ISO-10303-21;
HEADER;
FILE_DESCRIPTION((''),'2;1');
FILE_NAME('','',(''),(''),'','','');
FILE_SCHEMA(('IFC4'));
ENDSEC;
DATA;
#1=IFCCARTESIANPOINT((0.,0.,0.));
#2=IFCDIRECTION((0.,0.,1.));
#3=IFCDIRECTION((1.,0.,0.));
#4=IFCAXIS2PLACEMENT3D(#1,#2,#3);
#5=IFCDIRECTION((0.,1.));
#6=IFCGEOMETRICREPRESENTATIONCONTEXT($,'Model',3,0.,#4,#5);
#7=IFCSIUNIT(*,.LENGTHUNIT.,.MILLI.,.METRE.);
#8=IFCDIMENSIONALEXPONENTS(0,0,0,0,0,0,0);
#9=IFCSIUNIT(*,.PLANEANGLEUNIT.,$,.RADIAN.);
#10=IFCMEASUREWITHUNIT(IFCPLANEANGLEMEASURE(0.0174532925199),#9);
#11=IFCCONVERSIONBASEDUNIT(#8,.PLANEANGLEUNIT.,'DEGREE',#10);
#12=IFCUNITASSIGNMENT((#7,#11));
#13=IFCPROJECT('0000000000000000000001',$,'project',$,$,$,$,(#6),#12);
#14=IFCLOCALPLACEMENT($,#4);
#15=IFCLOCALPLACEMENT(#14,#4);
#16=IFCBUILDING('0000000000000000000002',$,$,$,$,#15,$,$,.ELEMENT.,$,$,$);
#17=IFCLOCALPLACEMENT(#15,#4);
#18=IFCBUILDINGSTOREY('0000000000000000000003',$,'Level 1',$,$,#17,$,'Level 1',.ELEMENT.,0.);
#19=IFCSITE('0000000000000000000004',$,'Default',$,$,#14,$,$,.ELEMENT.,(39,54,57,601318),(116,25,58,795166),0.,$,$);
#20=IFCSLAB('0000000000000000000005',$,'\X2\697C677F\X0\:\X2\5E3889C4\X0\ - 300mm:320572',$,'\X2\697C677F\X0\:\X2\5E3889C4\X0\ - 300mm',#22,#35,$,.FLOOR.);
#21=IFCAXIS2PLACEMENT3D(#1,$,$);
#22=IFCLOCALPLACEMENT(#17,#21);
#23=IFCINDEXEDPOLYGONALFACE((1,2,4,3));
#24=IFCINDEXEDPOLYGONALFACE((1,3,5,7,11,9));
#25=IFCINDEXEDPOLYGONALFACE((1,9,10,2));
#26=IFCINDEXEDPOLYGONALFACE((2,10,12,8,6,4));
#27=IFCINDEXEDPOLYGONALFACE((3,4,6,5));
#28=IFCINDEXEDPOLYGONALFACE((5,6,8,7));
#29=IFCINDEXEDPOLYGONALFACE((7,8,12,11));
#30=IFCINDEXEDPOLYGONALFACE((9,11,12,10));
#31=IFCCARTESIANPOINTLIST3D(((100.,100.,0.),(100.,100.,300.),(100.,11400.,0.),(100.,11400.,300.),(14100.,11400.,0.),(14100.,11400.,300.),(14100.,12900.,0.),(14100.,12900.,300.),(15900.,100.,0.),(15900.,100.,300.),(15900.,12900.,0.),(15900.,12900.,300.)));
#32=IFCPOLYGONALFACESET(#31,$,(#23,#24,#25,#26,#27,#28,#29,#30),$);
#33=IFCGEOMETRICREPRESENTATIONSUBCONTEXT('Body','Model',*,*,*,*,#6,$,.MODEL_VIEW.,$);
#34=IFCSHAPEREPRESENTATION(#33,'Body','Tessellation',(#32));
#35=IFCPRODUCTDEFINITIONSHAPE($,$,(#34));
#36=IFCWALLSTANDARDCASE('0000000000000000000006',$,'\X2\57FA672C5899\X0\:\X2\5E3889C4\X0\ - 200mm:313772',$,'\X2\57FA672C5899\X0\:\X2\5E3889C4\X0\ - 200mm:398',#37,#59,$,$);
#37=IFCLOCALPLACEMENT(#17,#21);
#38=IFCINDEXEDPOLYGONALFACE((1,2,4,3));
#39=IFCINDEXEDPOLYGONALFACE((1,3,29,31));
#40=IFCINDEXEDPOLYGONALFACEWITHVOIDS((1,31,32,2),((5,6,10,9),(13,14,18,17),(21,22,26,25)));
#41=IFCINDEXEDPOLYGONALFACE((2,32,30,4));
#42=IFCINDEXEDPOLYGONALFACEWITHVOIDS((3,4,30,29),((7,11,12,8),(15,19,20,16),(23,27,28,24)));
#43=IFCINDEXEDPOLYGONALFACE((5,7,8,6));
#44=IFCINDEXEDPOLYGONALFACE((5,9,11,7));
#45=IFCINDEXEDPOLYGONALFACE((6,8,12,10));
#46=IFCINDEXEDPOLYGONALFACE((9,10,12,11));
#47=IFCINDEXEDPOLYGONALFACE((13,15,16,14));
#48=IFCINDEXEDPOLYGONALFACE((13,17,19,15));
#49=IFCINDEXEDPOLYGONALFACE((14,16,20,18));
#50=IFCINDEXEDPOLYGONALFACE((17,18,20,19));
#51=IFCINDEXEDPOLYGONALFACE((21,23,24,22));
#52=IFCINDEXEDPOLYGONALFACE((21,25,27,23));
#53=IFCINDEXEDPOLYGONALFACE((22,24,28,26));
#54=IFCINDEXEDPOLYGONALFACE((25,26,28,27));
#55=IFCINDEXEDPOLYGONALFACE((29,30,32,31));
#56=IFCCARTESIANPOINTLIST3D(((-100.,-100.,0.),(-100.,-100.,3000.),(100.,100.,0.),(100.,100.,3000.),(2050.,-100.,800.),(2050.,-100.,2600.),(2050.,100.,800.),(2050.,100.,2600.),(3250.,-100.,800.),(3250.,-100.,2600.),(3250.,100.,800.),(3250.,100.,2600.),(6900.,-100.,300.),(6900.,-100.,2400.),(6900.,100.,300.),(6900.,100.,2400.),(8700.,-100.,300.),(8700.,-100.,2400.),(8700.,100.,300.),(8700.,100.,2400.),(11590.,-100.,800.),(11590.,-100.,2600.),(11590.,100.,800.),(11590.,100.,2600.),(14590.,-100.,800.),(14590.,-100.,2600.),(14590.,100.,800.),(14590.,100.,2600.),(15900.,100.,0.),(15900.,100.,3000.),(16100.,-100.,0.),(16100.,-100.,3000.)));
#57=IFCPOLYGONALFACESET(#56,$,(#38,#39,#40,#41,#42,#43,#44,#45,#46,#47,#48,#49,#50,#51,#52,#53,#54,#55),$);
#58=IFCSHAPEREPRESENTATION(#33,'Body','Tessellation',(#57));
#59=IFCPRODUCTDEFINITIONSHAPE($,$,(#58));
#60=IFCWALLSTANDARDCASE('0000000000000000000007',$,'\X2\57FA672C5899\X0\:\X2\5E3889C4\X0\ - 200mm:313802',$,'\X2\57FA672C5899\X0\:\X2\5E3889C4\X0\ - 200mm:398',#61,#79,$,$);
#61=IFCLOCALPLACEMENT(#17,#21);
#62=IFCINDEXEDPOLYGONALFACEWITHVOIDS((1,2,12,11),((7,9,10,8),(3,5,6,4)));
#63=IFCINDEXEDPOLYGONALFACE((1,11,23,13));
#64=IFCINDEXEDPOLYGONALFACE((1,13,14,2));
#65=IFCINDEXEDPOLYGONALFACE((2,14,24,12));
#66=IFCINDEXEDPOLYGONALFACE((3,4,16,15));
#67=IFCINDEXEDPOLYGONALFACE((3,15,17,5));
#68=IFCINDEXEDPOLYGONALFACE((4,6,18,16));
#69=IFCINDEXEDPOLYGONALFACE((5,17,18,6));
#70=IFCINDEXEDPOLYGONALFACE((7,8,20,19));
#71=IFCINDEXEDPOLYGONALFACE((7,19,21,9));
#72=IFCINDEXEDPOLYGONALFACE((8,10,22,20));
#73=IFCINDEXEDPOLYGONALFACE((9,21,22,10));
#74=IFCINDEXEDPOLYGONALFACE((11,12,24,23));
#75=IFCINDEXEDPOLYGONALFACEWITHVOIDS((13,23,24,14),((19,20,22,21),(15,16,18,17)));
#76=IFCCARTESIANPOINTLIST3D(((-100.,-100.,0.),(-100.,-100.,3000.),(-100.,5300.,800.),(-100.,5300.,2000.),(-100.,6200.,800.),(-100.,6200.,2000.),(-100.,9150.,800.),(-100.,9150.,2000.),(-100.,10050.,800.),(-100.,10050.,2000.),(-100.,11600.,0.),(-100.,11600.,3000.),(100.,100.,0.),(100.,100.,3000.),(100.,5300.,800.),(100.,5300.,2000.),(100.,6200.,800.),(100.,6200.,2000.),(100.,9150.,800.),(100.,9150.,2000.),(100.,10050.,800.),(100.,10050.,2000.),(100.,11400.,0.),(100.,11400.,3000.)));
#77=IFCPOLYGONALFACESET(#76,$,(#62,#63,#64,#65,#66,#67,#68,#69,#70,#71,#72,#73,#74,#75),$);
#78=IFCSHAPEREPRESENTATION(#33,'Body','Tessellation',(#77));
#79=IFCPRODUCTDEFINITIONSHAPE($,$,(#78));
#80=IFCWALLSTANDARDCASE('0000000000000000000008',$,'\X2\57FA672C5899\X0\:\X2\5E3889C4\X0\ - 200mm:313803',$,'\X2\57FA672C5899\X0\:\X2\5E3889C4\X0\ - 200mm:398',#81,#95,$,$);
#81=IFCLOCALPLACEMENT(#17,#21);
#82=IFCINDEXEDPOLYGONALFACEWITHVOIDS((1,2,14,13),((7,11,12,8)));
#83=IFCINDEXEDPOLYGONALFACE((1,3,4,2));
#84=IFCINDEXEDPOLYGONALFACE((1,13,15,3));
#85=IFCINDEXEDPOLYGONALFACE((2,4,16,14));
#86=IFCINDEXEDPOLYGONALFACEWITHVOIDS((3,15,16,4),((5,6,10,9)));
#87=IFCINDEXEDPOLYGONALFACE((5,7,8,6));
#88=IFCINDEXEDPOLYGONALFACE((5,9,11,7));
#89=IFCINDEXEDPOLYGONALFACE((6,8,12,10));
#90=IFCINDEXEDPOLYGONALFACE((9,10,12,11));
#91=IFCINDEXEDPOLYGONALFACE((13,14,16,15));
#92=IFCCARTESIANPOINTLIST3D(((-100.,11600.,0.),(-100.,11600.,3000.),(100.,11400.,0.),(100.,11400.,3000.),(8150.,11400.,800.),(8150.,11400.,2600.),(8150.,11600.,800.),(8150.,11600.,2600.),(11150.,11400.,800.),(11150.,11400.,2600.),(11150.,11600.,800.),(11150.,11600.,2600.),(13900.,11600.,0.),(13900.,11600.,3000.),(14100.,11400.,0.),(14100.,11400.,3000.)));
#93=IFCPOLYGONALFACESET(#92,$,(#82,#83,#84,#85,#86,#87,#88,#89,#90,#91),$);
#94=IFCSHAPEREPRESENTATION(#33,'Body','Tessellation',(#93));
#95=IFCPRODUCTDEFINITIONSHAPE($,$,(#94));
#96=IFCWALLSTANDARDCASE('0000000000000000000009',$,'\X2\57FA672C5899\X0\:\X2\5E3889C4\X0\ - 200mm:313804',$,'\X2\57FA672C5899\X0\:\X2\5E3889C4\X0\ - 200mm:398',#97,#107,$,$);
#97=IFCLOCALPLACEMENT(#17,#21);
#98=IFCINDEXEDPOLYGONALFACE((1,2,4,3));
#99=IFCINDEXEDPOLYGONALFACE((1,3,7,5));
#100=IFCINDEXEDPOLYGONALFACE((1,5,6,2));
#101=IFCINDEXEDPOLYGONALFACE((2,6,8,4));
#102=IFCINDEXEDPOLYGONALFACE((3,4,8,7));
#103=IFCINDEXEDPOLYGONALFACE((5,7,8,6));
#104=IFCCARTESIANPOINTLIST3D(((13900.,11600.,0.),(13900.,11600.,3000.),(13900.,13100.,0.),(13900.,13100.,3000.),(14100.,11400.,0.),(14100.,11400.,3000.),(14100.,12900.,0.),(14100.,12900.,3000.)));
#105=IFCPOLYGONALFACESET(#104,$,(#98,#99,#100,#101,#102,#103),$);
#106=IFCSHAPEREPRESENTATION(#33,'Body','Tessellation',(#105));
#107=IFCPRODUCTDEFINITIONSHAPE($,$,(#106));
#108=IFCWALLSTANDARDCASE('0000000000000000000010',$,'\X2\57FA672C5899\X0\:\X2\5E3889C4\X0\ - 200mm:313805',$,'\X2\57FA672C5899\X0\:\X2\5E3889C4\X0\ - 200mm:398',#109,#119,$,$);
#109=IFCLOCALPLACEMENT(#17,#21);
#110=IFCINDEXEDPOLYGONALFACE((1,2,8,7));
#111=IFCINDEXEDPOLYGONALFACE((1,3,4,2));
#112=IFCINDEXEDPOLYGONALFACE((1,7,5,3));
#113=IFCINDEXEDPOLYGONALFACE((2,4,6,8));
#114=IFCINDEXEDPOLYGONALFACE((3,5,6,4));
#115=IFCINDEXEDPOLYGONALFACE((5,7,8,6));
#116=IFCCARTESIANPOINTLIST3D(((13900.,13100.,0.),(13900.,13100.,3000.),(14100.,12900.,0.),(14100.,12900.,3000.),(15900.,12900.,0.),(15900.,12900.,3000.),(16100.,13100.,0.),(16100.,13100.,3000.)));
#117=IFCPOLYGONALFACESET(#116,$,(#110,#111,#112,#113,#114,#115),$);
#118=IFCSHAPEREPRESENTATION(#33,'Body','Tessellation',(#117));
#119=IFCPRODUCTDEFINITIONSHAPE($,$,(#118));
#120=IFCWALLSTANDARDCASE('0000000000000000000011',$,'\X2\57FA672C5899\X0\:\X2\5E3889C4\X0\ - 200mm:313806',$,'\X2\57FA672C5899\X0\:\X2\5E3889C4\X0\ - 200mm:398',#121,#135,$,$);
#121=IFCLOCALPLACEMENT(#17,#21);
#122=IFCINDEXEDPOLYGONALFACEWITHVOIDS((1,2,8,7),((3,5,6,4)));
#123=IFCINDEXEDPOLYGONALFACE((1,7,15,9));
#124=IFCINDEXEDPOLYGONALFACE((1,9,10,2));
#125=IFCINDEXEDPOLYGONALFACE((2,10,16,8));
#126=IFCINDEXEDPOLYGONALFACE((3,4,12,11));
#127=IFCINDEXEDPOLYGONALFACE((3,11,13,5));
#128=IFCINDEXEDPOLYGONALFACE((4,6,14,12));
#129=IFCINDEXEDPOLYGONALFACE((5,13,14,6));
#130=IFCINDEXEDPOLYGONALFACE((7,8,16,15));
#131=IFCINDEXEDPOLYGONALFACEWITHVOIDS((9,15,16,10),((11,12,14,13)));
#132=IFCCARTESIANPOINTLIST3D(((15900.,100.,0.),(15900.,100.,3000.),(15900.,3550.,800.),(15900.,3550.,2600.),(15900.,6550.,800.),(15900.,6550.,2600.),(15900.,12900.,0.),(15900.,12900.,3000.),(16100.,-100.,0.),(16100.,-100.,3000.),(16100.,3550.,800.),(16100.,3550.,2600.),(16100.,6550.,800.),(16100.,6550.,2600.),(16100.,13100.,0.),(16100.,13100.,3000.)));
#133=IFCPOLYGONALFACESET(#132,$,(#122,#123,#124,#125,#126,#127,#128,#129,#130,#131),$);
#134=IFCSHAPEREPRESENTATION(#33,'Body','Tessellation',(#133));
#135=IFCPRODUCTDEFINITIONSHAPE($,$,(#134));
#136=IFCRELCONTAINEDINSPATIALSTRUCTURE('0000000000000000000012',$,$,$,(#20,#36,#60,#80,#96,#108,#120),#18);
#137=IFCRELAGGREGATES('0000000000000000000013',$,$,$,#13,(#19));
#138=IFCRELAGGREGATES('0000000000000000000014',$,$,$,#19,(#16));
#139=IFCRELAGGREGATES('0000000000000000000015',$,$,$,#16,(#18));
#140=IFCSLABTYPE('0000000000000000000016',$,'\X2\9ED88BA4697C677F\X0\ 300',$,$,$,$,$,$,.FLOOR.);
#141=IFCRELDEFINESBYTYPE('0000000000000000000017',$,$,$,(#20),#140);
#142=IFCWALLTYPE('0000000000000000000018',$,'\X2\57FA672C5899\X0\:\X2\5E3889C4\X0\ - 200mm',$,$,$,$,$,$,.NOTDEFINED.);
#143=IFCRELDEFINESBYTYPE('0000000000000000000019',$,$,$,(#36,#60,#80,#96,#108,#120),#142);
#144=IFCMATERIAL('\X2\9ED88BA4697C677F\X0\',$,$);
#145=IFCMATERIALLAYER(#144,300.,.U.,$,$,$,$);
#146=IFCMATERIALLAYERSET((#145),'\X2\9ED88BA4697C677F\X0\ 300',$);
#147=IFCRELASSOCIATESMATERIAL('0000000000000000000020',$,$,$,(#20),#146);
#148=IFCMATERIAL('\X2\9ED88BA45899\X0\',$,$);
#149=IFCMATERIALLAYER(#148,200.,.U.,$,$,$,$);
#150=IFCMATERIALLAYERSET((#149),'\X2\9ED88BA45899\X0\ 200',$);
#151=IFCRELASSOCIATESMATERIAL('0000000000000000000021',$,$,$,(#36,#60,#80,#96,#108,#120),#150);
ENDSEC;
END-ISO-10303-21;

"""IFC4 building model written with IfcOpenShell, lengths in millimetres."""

from ifc_helpers import new_model, entity, si_unit, converted_unit, direction, frame, origin_with_axes, place, context, subcontext, project, spatial, polyline, outline, extrude, material, layer, layer_set, layer_usage, type_object, element, save


model = new_model("IFC4")

# Units and contexts
model_context_1 = context("Model", 3, precision=0.0, world=origin_with_axes(), true_north=direction((0.0, 1.0)))
model_context_2 = context("Model", 3, precision=0.0, world=origin_with_axes(), true_north=direction((0.0, 1.0)))
body_context_1 = subcontext(model_context_1, "Body", "Model", "MODEL_VIEW")
body_context_2 = subcontext(model_context_2, "Body", "Model", "MODEL_VIEW")
ifc_project = project(units=[si_unit("LENGTHUNIT", "METRE", prefix="MILLI"), converted_unit("PLANEANGLEUNIT", "DEGREE", entity("IfcPlaneAngleMeasure", 0.0174532925199), si_unit("PLANEANGLEUNIT", "RADIAN"), dimensions=[0, 0, 0, 0, 0, 0, 0])], contexts=[model_context_1])

# Site, building, storey
site_placement = place(None, origin_with_axes())
site = spatial("IfcSite", under=ifc_project, at=site_placement, Name="Default", CompositionType="ELEMENT", RefLatitude=(39, 54, 57, 601318), RefLongitude=(116, 25, 58, 795166), RefElevation=0.0)
building_placement = place(site_placement, origin_with_axes())
building = spatial("IfcBuilding", under=site, at=building_placement, CompositionType="ELEMENT")
storey_placement = place(building_placement, origin_with_axes())
storey = spatial("IfcBuildingStorey", under=building, at=storey_placement, Name="Level 1", LongName="Level 1", CompositionType="ELEMENT", Elevation=0.0)

# Slab
ifc_material_1 = material(Name="默认楼板")
ifc_layer_1 = layer(ifc_material_1, 300.0, ventilated="UNKNOWN")
ifc_layer_set_1 = layer_set([ifc_layer_1], Name="默认楼板 300")
ifc_layer_usage_1 = layer_usage(ifc_layer_set_1, "AXIS3", "NEGATIVE", 300.0)
slab_type = type_object("IfcSlabType", Name="默认楼板 300", PredefinedType="FLOOR")
slab_placement = place(storey_placement, frame((100.0, 100.0, 0.0), z_axis=(0.0, 0.0, 1.0), x_axis=(1.0, 0.0, 0.0)))
element("IfcSlab", 1, at=slab_placement, inside=storey, type_object=slab_type, material=ifc_layer_usage_1, Name="楼板:常规 - 300mm:320572", ObjectType="楼板:常规 - 300mm", PredefinedType="FLOOR", context=body_context_1, shape_type="SweptSolid", body=[
    extrude(outline(polyline([(0.0, 0.0), (15800.0, 0.0), (15800.0, 12800.0), (14000.0, 12800.0), (14000.0, 11300.0), (0.0, 11300.0), (0.0, 0.0)])), origin_with_axes(), (0.0, 0.0, 1.0), 300.0),
])

# Walls, openings
ifc_material_2 = material(Name="默认墙")
ifc_layer_2 = layer(ifc_material_2, 200.0, ventilated="UNKNOWN")
ifc_layer_set_2 = layer_set([ifc_layer_2], Name="默认墙 200")
ifc_layer_usage_2 = layer_usage(ifc_layer_set_2, "AXIS2", "POSITIVE", -100.0)
wall_type_1 = type_object("IfcWallType", Name="基本墙:常规 - 200mm", PredefinedType="NOTDEFINED")
wall_1_placement = place(storey_placement, frame((16000.0, 0.0, 0.0), z_axis=(0.0, 0.0, 1.0), x_axis=(-1.0, 0.0, 0.0)))
wall_1 = element("IfcWallStandardCase", 2, at=wall_1_placement, inside=storey, type_object=wall_type_1, material=ifc_layer_usage_2, Name="基本墙:常规 - 200mm:313772", ObjectType="基本墙:常规 - 200mm:398", context=body_context_1, shape_type="SweptSolid", body=[
    extrude(outline(polyline([(100.0, -100.0), (15900.0, -100.0), (16100.0, 100.0), (-100.0, 100.0), (100.0, -100.0)])), origin_with_axes(), (0.0, 0.0, 1.0), 3000.0),
])
placement_1 = place(None, origin_with_axes())
placement_2 = place(placement_1, origin_with_axes())
placement_3 = place(placement_2, origin_with_axes())
placement_4 = place(placement_3, frame((16000.0, 0.0, 0.0), z_axis=(0.0, 0.0, 1.0), x_axis=(-1.0, 0.0, 0.0)))
opening_1_placement = place(placement_4, frame((13350.0, 0.0, 800.0), z_axis=(0.0, 0.0, 1.0), x_axis=(1.0, 0.0, 0.0)))
element("IfcOpeningElement", 3, at=opening_1_placement, cuts=wall_1, context=body_context_2, shape_type="SweptSolid", body=[
    extrude(outline(polyline([(-600.0, 0.0), (-600.0, -1800.0), (600.0, -1800.0), (600.0, 0.0), (-600.0, 0.0)])), frame((0.0, -100.0, 0.0), z_axis=(0.0, 1.0, 0.0), x_axis=(1.0, 0.0, 0.0)), (0.0, 0.0, 1.0), 200.0),
])
opening_2_placement = place(placement_4, frame((2910.0, 0.0, 800.0), z_axis=(0.0, 0.0, 1.0), x_axis=(1.0, 0.0, 0.0)))
element("IfcOpeningElement", 4, at=opening_2_placement, cuts=wall_1, context=body_context_2, shape_type="SweptSolid", body=[
    extrude(outline(polyline([(-1500.0, 0.0), (-1500.0, -1800.0), (1500.0, -1800.0), (1500.0, 0.0), (-1500.0, 0.0)])), frame((0.0, -100.0, 0.0), z_axis=(0.0, 1.0, 0.0), x_axis=(1.0, 0.0, 0.0)), (0.0, 0.0, 1.0), 200.0),
])
opening_3_placement = place(placement_4, frame((8200.0, 0.0, 300.0), z_axis=(0.0, 0.0, 1.0), x_axis=(1.0, 0.0, 0.0)))
element("IfcOpeningElement", 5, at=opening_3_placement, cuts=wall_1, context=body_context_2, shape_type="SweptSolid", body=[
    extrude(outline(polyline([(-900.0, 0.0), (-900.0, -2100.0), (900.0, -2100.0), (900.0, 0.0), (-900.0, 0.0)])), frame((0.0, -100.0, 0.0), z_axis=(0.0, 1.0, 0.0), x_axis=(1.0, 0.0, 0.0)), (0.0, 0.0, 1.0), 200.0),
])
ifc_layer_usage_3 = layer_usage(ifc_layer_set_2, "AXIS2", "POSITIVE", -100.0)
wall_2_placement = place(storey_placement, frame((0.0, 0.0, 0.0), z_axis=(0.0, 0.0, 1.0), x_axis=(0.0, 1.0, 0.0)))
wall_2 = element("IfcWallStandardCase", 6, at=wall_2_placement, inside=storey, type_object=wall_type_1, material=ifc_layer_usage_3, Name="基本墙:常规 - 200mm:313802", ObjectType="基本墙:常规 - 200mm:398", context=body_context_1, shape_type="SweptSolid", body=[
    extrude(outline(polyline([(100.0, -100.0), (11400.0, -100.0), (11600.0, 100.0), (-100.0, 100.0), (100.0, -100.0)])), origin_with_axes(), (0.0, 0.0, 1.0), 3000.0),
])
placement_5 = place(placement_3, frame((0.0, 0.0, 0.0), z_axis=(0.0, 0.0, 1.0), x_axis=(0.0, 1.0, 0.0)))
opening_4_placement = place(placement_5, frame((5750.0, 0.0, 800.0), z_axis=(0.0, 0.0, 1.0), x_axis=(1.0, 0.0, 0.0)))
element("IfcOpeningElement", 7, at=opening_4_placement, cuts=wall_2, context=body_context_2, shape_type="SweptSolid", body=[
    extrude(outline(polyline([(450.0, -1200.0), (450.0, 0.0), (-450.0, 0.0), (-450.0, -1200.0), (450.0, -1200.0)])), frame((0.0, 100.0, 0.0), z_axis=(0.0, -1.0, 0.0), x_axis=(-1.0, 0.0, 0.0)), (0.0, 0.0, 1.0), 200.0),
])
opening_5_placement = place(placement_5, frame((9600.0, 0.0, 800.0), z_axis=(0.0, 0.0, 1.0), x_axis=(1.0, 0.0, 0.0)))
element("IfcOpeningElement", 8, at=opening_5_placement, cuts=wall_2, context=body_context_2, shape_type="SweptSolid", body=[
    extrude(outline(polyline([(450.0, -1200.0), (450.0, 0.0), (-450.0, 0.0), (-450.0, -1200.0), (450.0, -1200.0)])), frame((0.0, 100.0, 0.0), z_axis=(0.0, -1.0, 0.0), x_axis=(-1.0, 0.0, 0.0)), (0.0, 0.0, 1.0), 200.0),
])

# Wall, opening
ifc_layer_usage_4 = layer_usage(ifc_layer_set_2, "AXIS2", "POSITIVE", -100.0)
wall_3_placement = place(storey_placement, frame((0.0, 11500.0, 0.0), z_axis=(0.0, 0.0, 1.0), x_axis=(1.0, 0.0, 0.0)))
wall_3 = element("IfcWallStandardCase", 9, at=wall_3_placement, inside=storey, type_object=wall_type_1, material=ifc_layer_usage_4, Name="基本墙:常规 - 200mm:313803", ObjectType="基本墙:常规 - 200mm:398", context=body_context_1, shape_type="SweptSolid", body=[
    extrude(outline(polyline([(100.0, -100.0), (14100.0, -100.0), (13900.0, 100.0), (-100.0, 100.0), (100.0, -100.0)])), origin_with_axes(), (0.0, 0.0, 1.0), 3000.0),
])
placement_6 = place(placement_3, frame((0.0, 11500.0, 0.0), z_axis=(0.0, 0.0, 1.0), x_axis=(1.0, 0.0, 0.0)))
opening_6_placement = place(placement_6, frame((9650.0, 0.0, 800.0), z_axis=(0.0, 0.0, 1.0), x_axis=(1.0, 0.0, 0.0)))
element("IfcOpeningElement", 10, at=opening_6_placement, cuts=wall_3, context=body_context_2, shape_type="SweptSolid", body=[
    extrude(outline(polyline([(-1500.0, 0.0), (-1500.0, -1800.0), (1500.0, -1800.0), (1500.0, 0.0), (-1500.0, 0.0)])), frame((0.0, -100.0, 0.0), z_axis=(0.0, 1.0, 0.0), x_axis=(1.0, 0.0, 0.0)), (0.0, 0.0, 1.0), 200.0),
])

# Walls
ifc_layer_usage_5 = layer_usage(ifc_layer_set_2, "AXIS2", "POSITIVE", -100.0)
wall_4_placement = place(storey_placement, frame((14000.0, 11500.0, 0.0), z_axis=(0.0, 0.0, 1.0), x_axis=(0.0, 1.0, 0.0)))
element("IfcWallStandardCase", 11, at=wall_4_placement, inside=storey, type_object=wall_type_1, material=ifc_layer_usage_5, Name="基本墙:常规 - 200mm:313804", ObjectType="基本墙:常规 - 200mm:398", context=body_context_1, shape_type="SweptSolid", body=[
    extrude(outline(polyline([(-100.0, -100.0), (1400.0, -100.0), (1600.0, 100.0), (100.0, 100.0), (-100.0, -100.0)])), origin_with_axes(), (0.0, 0.0, 1.0), 3000.0),
])
ifc_layer_usage_6 = layer_usage(ifc_layer_set_2, "AXIS2", "POSITIVE", -100.0)
wall_5_placement = place(storey_placement, frame((14000.0, 13000.0, 0.0), z_axis=(0.0, 0.0, 1.0), x_axis=(1.0, 0.0, 0.0)))
element("IfcWallStandardCase", 12, at=wall_5_placement, inside=storey, type_object=wall_type_1, material=ifc_layer_usage_6, Name="基本墙:常规 - 200mm:313805", ObjectType="基本墙:常规 - 200mm:398", context=body_context_1, shape_type="SweptSolid", body=[
    extrude(outline(polyline([(100.0, -100.0), (1900.0, -100.0), (2100.0, 100.0), (-100.0, 100.0), (100.0, -100.0)])), origin_with_axes(), (0.0, 0.0, 1.0), 3000.0),
])

# Wall, opening
ifc_layer_usage_7 = layer_usage(ifc_layer_set_2, "AXIS2", "POSITIVE", -100.0)
wall_6_placement = place(storey_placement, frame((16000.0, 13000.0, 0.0), z_axis=(0.0, 0.0, 1.0), x_axis=(0.0, -1.0, 0.0)))
wall_6 = element("IfcWallStandardCase", 13, at=wall_6_placement, inside=storey, type_object=wall_type_1, material=ifc_layer_usage_7, Name="基本墙:常规 - 200mm:313806", ObjectType="基本墙:常规 - 200mm:398", context=body_context_1, shape_type="SweptSolid", body=[
    extrude(outline(polyline([(100.0, -100.0), (12900.0, -100.0), (13100.0, 100.0), (-100.0, 100.0), (100.0, -100.0)])), origin_with_axes(), (0.0, 0.0, 1.0), 3000.0),
])
placement_7 = place(placement_3, frame((16000.0, 13000.0, 0.0), z_axis=(0.0, 0.0, 1.0), x_axis=(0.0, -1.0, 0.0)))
opening_7_placement = place(placement_7, frame((7950.0, 0.0, 800.0), z_axis=(0.0, 0.0, 1.0), x_axis=(1.0, 0.0, 0.0)))
element("IfcOpeningElement", 14, at=opening_7_placement, cuts=wall_6, context=body_context_2, shape_type="SweptSolid", body=[
    extrude(outline(polyline([(-1500.0, 0.0), (-1500.0, -1800.0), (1500.0, -1800.0), (1500.0, 0.0), (-1500.0, 0.0)])), frame((0.0, -100.0, 0.0), z_axis=(0.0, 1.0, 0.0), x_axis=(1.0, 0.0, 0.0)), (0.0, 0.0, 1.0), 200.0),
])

save(model, "model.ifc")
